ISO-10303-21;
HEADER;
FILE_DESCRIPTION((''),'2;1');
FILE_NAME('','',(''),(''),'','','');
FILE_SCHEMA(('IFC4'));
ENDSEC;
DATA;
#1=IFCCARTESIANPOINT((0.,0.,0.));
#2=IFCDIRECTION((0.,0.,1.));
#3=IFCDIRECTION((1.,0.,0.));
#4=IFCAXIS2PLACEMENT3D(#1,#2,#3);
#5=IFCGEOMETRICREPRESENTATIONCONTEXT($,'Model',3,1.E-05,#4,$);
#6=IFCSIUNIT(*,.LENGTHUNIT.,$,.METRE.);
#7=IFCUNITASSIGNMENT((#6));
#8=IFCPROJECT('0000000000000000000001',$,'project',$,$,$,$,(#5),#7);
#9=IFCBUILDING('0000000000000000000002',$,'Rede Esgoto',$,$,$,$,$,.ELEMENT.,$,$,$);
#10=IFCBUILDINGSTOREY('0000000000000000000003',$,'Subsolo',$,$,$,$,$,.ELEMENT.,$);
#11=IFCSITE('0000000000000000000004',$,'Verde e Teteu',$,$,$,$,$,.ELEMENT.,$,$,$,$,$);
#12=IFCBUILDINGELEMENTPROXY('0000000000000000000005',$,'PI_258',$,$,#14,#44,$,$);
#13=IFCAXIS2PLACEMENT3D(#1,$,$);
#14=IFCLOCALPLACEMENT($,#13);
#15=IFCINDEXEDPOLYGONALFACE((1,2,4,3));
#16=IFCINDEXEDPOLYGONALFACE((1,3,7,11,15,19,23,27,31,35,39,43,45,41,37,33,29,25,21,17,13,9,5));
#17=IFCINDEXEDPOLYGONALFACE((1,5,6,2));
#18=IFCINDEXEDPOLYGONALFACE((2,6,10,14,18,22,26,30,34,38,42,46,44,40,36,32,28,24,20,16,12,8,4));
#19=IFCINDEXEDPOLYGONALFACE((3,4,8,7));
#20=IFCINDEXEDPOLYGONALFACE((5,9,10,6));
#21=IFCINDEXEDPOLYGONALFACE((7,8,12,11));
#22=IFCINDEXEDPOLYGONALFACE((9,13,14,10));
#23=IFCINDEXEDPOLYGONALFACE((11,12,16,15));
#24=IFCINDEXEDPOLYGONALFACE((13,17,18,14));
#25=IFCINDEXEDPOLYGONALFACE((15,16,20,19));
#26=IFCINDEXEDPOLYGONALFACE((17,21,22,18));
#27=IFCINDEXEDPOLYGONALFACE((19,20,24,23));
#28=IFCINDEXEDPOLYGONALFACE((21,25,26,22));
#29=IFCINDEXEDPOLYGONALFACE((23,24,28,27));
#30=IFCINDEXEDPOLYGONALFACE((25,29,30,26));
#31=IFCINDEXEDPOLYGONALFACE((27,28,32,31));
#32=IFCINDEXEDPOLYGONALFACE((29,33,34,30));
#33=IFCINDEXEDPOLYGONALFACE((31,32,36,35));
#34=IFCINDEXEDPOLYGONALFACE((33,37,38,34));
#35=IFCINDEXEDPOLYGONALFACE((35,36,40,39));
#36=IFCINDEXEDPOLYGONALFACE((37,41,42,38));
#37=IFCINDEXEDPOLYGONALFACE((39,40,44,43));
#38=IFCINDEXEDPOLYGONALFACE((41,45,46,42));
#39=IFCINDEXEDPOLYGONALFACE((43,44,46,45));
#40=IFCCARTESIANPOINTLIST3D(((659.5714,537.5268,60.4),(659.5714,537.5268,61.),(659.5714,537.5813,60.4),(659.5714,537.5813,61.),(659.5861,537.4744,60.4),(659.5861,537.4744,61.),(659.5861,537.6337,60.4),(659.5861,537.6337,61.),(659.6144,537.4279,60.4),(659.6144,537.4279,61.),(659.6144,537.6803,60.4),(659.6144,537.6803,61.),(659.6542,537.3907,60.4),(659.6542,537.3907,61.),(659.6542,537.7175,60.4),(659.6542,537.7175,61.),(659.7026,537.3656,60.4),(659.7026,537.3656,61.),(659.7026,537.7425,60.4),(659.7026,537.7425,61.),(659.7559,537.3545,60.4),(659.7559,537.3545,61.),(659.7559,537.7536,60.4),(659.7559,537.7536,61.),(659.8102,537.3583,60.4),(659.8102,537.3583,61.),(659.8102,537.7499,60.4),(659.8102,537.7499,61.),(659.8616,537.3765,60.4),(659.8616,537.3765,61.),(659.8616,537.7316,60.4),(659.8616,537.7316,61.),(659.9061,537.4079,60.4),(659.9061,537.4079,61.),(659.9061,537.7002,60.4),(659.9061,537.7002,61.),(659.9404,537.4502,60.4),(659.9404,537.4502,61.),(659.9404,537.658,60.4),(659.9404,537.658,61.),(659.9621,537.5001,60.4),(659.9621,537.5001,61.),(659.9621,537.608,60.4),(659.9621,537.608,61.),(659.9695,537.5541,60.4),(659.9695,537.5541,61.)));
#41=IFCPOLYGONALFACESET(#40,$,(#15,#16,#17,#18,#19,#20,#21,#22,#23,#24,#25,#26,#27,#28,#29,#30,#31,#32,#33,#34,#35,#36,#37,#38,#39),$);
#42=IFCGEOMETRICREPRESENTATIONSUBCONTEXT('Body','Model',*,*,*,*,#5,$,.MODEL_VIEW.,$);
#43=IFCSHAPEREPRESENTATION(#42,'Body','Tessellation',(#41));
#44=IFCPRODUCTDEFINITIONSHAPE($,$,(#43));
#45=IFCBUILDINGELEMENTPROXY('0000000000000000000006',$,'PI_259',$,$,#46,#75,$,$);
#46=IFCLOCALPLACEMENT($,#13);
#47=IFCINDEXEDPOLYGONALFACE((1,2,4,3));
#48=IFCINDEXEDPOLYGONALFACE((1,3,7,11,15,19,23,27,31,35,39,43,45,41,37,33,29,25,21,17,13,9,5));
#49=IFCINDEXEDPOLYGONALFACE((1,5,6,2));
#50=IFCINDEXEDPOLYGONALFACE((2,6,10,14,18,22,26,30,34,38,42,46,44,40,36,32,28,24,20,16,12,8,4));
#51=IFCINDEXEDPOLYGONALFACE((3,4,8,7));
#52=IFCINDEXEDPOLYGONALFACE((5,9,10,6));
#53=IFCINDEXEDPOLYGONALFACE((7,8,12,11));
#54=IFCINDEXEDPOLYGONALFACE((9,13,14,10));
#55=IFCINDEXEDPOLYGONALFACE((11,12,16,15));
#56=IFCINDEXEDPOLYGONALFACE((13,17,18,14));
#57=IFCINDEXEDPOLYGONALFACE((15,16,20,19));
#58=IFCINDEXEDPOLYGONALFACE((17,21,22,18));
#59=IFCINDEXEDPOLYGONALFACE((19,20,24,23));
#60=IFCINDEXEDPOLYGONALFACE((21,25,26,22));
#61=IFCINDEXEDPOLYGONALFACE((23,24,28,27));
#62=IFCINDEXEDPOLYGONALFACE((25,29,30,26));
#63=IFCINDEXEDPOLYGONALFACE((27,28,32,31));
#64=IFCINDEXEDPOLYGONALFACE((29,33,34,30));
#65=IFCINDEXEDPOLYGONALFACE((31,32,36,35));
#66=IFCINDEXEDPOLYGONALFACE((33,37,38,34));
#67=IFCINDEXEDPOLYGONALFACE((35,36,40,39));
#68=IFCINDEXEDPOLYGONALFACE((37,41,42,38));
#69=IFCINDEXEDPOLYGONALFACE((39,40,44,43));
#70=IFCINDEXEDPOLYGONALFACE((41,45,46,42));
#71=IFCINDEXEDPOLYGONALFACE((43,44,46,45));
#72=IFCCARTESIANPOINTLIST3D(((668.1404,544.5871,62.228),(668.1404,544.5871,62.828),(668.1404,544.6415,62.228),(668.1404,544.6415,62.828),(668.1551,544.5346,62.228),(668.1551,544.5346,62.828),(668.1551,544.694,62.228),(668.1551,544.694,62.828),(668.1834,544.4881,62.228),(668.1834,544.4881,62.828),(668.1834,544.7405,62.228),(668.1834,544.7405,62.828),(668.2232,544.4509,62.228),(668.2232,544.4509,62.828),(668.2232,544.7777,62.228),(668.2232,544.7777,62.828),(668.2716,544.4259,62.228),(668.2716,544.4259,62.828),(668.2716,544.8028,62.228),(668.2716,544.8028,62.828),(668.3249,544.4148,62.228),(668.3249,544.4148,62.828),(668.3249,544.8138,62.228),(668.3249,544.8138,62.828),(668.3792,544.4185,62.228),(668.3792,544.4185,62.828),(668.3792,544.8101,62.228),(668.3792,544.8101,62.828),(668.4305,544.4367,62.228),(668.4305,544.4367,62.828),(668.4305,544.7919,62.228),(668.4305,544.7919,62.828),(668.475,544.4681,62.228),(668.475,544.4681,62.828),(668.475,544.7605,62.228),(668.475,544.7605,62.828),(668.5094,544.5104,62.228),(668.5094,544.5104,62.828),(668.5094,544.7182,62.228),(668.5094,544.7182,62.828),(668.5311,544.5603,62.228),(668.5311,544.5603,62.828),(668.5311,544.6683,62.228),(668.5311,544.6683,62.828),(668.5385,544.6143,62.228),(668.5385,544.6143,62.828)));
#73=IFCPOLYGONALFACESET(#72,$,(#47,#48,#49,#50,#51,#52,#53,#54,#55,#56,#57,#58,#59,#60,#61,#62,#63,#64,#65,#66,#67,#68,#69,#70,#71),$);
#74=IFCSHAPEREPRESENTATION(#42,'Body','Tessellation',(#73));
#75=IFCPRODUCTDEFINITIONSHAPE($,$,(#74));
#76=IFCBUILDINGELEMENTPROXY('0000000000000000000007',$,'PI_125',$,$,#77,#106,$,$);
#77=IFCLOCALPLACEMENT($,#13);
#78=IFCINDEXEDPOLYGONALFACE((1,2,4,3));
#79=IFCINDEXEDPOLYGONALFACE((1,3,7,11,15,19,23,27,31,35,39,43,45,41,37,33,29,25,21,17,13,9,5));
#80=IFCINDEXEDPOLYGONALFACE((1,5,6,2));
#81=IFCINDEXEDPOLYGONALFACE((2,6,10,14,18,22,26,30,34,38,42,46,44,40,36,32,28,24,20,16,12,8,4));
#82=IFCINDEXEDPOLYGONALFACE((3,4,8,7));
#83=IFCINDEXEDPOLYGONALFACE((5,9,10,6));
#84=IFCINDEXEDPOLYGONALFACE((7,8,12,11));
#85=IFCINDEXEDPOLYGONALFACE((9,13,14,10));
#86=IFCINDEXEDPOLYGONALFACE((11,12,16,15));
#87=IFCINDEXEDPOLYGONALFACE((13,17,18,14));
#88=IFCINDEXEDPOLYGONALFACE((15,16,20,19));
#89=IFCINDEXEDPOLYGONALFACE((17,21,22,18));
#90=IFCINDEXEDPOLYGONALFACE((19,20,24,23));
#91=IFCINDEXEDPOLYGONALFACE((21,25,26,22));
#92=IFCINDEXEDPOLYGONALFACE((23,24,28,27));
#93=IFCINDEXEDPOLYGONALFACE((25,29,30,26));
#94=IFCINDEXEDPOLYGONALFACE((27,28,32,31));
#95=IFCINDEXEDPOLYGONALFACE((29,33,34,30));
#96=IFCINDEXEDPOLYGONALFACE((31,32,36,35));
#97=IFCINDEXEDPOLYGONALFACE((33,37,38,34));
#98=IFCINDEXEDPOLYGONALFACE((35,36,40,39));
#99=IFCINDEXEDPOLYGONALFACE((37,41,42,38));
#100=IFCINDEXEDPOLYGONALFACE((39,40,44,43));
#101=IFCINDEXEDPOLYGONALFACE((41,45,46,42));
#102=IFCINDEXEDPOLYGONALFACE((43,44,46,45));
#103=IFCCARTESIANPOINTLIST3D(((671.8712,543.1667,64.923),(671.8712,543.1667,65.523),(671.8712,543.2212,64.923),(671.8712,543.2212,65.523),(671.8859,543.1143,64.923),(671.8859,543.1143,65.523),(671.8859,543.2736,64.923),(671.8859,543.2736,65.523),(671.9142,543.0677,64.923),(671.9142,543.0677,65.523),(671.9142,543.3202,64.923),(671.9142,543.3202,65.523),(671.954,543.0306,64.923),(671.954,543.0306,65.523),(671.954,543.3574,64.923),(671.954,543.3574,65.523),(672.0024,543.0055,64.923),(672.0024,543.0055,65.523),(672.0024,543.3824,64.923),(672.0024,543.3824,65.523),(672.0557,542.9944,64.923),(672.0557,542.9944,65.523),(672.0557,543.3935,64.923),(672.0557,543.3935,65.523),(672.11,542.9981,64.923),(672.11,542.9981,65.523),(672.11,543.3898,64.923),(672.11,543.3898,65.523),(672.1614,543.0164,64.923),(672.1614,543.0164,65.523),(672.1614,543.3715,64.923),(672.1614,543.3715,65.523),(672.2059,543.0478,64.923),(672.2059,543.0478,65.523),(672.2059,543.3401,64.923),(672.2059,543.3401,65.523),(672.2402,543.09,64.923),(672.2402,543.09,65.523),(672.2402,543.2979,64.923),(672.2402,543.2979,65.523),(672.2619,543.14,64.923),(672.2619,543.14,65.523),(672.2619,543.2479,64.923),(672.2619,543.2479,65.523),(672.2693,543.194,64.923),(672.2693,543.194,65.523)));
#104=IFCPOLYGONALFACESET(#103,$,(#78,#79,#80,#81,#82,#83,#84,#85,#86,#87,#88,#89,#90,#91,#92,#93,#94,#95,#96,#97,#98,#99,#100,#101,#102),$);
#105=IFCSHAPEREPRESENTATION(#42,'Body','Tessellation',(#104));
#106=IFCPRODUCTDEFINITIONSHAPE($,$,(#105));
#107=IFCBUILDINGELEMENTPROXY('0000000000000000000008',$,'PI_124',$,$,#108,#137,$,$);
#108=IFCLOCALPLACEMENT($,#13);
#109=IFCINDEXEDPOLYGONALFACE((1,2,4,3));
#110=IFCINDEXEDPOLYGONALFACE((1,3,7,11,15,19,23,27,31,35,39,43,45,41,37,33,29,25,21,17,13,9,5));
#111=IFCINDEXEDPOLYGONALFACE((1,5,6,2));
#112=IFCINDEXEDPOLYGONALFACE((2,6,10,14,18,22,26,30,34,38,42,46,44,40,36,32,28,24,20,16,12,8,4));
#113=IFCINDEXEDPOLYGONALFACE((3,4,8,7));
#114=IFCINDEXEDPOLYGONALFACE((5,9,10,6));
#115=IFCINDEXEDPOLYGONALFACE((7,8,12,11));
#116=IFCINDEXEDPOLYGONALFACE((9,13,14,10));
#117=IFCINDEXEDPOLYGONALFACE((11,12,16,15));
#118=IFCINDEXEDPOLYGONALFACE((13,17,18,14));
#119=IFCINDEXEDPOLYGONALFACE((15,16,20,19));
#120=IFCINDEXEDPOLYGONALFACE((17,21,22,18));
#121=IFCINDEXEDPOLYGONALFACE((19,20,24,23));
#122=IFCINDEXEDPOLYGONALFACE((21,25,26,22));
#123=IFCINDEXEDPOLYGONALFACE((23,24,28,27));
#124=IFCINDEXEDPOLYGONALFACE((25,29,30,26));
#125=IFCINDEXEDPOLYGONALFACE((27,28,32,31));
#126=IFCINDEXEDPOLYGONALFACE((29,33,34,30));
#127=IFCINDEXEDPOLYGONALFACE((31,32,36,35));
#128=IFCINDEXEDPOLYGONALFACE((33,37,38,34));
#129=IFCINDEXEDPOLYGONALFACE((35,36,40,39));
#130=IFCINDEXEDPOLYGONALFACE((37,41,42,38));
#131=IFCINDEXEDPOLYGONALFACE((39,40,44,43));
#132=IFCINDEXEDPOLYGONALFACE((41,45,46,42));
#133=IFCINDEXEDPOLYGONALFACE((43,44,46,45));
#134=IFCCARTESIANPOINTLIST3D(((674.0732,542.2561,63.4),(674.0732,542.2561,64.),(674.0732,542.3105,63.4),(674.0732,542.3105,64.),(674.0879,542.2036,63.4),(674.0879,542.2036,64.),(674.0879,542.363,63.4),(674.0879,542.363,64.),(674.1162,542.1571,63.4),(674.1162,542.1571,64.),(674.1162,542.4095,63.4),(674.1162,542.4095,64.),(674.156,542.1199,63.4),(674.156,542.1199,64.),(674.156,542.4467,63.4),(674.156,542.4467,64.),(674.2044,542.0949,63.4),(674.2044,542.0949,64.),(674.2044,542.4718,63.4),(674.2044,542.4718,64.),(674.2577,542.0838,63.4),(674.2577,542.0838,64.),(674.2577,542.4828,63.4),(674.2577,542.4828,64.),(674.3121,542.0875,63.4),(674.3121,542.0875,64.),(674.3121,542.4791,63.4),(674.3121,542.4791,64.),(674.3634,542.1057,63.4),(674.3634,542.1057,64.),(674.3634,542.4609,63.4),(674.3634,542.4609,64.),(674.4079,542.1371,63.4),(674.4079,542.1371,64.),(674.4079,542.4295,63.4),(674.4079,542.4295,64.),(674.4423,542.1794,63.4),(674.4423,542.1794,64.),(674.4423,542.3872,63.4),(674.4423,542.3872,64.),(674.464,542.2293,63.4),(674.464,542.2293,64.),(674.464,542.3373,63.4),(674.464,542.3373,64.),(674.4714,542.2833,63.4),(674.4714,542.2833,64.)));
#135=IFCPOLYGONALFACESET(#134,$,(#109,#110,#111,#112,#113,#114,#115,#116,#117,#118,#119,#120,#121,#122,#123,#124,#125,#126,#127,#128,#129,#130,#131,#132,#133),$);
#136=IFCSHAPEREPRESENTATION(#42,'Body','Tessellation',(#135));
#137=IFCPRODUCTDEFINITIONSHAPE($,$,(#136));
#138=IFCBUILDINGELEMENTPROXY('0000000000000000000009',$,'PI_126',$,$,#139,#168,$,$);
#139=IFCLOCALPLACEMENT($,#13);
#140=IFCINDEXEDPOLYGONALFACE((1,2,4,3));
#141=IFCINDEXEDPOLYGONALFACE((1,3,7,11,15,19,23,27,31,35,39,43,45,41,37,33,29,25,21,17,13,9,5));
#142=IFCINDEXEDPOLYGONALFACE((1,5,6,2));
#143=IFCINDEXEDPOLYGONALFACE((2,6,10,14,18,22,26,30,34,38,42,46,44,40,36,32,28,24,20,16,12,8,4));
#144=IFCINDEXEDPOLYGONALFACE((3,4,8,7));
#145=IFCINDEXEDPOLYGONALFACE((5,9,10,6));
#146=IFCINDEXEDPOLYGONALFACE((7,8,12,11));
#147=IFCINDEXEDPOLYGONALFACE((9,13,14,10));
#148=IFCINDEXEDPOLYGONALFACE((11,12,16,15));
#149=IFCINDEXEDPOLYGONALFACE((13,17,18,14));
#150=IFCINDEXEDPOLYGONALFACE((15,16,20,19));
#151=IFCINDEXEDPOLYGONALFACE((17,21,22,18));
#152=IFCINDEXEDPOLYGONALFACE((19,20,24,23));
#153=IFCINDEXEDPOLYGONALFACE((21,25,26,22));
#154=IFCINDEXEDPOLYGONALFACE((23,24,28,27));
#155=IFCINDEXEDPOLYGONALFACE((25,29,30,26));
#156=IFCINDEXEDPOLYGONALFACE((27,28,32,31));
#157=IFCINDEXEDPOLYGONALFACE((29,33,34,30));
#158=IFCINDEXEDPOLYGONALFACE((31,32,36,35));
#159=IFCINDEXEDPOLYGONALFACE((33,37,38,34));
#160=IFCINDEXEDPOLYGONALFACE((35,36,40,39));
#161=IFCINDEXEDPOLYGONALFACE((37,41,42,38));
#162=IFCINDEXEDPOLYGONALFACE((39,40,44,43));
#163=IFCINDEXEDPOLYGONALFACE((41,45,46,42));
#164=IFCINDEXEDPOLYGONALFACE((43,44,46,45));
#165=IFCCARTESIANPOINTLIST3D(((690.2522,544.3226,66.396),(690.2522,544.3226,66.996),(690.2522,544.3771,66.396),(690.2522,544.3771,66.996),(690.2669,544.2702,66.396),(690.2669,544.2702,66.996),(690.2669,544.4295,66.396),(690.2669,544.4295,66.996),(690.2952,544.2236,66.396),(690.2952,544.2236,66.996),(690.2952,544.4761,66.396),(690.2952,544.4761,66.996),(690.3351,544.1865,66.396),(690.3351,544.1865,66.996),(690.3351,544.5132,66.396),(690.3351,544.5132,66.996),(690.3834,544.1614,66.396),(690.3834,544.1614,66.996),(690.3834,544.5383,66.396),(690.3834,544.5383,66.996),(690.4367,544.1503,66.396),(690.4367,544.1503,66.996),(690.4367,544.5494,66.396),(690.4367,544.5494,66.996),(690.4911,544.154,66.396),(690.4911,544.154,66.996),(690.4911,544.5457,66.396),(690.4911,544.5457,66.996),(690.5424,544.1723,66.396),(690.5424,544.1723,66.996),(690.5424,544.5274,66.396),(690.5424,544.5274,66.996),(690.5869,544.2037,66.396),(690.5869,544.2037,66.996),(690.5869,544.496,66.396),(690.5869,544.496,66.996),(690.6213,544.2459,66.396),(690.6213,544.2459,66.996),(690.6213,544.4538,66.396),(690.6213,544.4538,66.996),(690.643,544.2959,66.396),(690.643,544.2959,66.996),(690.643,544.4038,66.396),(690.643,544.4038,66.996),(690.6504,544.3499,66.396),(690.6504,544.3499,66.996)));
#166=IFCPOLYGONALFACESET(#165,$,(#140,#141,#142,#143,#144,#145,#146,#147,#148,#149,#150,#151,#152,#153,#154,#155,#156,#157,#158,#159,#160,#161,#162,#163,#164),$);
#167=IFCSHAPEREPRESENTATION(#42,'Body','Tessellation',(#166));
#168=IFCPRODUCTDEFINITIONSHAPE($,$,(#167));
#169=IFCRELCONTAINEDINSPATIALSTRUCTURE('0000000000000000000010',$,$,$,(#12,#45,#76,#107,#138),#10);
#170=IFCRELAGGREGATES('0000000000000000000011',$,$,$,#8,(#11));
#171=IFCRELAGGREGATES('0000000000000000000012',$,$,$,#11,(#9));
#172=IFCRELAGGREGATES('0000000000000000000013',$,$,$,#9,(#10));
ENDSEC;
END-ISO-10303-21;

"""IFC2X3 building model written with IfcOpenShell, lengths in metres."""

from ifc_helpers import new_model, si_unit, frame, origin_with_axes, origin_2d, place, context, subcontext, project, spatial, circle, extrude, element, save


model = new_model("IFC2X3")

# Units and contexts
model_context = context("Model", 3, precision=1e-05, world=origin_with_axes())
body_context = subcontext(model_context, "Body", "Model", "MODEL_VIEW")
ifc_project = project(units=[si_unit("LENGTHUNIT", "METRE")], contexts=[model_context])

# Site, building, storey
site = spatial("IfcSite", under=ifc_project, Name="Verde e Teteu", CompositionType="ELEMENT")
building = spatial("IfcBuilding", under=site, Name="Rede Esgoto", CompositionType="ELEMENT")
storey = spatial("IfcBuildingStorey", under=building, Name="Subsolo", CompositionType="ELEMENT")

# Building element proxies
for number, where, z_axis, x_axis, name in (
    (1, (659.7695, 537.5541, 60.4), (0.0, 0.0, 1.0), (1.0, 0.0, 0.0), "PI_258"),
    (2, (668.3385, 544.6143, 62.228), (0.0, 0.0, 1.0), (1.0, 0.0, 0.0), "PI_259"),
):
    element("IfcBuildingElementProxy", number, at=place(None, frame(where, z_axis=z_axis, x_axis=x_axis)), inside=storey, Name=name, context=body_context, shape_type="SweptSolid", body=[
        extrude(circle(Radius=0.2, at=origin_2d()), origin_with_axes(), (0.0, 0.0, 1.0), 0.6),
    ])
proxy_1_placement = place(None, frame((672.0693, 543.194, 64.923), z_axis=(0.0, 0.0, 1.0), x_axis=(1.0, 0.0, 0.0)))
element("IfcBuildingElementProxy", 3, at=proxy_1_placement, inside=storey, Name="PI_125", context=body_context, shape_type="SweptSolid", body=[
    extrude(circle(Radius=0.2, at=origin_2d()), origin_with_axes(), (0.0, 0.0, 1.0), 0.6),
])
proxy_2_placement = place(None, frame((674.2714, 542.2833, 63.4), z_axis=(0.0, 0.0, 1.0), x_axis=(1.0, 0.0, 0.0)))
element("IfcBuildingElementProxy", 4, at=proxy_2_placement, inside=storey, Name="PI_124", context=body_context, shape_type="SweptSolid", body=[
    extrude(circle(Radius=0.2, at=origin_2d()), origin_with_axes(), (0.0, 0.0, 1.0), 0.6),
])
proxy_3_placement = place(None, frame((690.4504, 544.3499, 66.396), z_axis=(0.0, 0.0, 1.0), x_axis=(1.0, 0.0, 0.0)))
element("IfcBuildingElementProxy", 5, at=proxy_3_placement, inside=storey, Name="PI_126", context=body_context, shape_type="SweptSolid", body=[
    extrude(circle(Radius=0.2, at=origin_2d()), origin_with_axes(), (0.0, 0.0, 1.0), 0.6),
])

save(model, "model.ifc")
